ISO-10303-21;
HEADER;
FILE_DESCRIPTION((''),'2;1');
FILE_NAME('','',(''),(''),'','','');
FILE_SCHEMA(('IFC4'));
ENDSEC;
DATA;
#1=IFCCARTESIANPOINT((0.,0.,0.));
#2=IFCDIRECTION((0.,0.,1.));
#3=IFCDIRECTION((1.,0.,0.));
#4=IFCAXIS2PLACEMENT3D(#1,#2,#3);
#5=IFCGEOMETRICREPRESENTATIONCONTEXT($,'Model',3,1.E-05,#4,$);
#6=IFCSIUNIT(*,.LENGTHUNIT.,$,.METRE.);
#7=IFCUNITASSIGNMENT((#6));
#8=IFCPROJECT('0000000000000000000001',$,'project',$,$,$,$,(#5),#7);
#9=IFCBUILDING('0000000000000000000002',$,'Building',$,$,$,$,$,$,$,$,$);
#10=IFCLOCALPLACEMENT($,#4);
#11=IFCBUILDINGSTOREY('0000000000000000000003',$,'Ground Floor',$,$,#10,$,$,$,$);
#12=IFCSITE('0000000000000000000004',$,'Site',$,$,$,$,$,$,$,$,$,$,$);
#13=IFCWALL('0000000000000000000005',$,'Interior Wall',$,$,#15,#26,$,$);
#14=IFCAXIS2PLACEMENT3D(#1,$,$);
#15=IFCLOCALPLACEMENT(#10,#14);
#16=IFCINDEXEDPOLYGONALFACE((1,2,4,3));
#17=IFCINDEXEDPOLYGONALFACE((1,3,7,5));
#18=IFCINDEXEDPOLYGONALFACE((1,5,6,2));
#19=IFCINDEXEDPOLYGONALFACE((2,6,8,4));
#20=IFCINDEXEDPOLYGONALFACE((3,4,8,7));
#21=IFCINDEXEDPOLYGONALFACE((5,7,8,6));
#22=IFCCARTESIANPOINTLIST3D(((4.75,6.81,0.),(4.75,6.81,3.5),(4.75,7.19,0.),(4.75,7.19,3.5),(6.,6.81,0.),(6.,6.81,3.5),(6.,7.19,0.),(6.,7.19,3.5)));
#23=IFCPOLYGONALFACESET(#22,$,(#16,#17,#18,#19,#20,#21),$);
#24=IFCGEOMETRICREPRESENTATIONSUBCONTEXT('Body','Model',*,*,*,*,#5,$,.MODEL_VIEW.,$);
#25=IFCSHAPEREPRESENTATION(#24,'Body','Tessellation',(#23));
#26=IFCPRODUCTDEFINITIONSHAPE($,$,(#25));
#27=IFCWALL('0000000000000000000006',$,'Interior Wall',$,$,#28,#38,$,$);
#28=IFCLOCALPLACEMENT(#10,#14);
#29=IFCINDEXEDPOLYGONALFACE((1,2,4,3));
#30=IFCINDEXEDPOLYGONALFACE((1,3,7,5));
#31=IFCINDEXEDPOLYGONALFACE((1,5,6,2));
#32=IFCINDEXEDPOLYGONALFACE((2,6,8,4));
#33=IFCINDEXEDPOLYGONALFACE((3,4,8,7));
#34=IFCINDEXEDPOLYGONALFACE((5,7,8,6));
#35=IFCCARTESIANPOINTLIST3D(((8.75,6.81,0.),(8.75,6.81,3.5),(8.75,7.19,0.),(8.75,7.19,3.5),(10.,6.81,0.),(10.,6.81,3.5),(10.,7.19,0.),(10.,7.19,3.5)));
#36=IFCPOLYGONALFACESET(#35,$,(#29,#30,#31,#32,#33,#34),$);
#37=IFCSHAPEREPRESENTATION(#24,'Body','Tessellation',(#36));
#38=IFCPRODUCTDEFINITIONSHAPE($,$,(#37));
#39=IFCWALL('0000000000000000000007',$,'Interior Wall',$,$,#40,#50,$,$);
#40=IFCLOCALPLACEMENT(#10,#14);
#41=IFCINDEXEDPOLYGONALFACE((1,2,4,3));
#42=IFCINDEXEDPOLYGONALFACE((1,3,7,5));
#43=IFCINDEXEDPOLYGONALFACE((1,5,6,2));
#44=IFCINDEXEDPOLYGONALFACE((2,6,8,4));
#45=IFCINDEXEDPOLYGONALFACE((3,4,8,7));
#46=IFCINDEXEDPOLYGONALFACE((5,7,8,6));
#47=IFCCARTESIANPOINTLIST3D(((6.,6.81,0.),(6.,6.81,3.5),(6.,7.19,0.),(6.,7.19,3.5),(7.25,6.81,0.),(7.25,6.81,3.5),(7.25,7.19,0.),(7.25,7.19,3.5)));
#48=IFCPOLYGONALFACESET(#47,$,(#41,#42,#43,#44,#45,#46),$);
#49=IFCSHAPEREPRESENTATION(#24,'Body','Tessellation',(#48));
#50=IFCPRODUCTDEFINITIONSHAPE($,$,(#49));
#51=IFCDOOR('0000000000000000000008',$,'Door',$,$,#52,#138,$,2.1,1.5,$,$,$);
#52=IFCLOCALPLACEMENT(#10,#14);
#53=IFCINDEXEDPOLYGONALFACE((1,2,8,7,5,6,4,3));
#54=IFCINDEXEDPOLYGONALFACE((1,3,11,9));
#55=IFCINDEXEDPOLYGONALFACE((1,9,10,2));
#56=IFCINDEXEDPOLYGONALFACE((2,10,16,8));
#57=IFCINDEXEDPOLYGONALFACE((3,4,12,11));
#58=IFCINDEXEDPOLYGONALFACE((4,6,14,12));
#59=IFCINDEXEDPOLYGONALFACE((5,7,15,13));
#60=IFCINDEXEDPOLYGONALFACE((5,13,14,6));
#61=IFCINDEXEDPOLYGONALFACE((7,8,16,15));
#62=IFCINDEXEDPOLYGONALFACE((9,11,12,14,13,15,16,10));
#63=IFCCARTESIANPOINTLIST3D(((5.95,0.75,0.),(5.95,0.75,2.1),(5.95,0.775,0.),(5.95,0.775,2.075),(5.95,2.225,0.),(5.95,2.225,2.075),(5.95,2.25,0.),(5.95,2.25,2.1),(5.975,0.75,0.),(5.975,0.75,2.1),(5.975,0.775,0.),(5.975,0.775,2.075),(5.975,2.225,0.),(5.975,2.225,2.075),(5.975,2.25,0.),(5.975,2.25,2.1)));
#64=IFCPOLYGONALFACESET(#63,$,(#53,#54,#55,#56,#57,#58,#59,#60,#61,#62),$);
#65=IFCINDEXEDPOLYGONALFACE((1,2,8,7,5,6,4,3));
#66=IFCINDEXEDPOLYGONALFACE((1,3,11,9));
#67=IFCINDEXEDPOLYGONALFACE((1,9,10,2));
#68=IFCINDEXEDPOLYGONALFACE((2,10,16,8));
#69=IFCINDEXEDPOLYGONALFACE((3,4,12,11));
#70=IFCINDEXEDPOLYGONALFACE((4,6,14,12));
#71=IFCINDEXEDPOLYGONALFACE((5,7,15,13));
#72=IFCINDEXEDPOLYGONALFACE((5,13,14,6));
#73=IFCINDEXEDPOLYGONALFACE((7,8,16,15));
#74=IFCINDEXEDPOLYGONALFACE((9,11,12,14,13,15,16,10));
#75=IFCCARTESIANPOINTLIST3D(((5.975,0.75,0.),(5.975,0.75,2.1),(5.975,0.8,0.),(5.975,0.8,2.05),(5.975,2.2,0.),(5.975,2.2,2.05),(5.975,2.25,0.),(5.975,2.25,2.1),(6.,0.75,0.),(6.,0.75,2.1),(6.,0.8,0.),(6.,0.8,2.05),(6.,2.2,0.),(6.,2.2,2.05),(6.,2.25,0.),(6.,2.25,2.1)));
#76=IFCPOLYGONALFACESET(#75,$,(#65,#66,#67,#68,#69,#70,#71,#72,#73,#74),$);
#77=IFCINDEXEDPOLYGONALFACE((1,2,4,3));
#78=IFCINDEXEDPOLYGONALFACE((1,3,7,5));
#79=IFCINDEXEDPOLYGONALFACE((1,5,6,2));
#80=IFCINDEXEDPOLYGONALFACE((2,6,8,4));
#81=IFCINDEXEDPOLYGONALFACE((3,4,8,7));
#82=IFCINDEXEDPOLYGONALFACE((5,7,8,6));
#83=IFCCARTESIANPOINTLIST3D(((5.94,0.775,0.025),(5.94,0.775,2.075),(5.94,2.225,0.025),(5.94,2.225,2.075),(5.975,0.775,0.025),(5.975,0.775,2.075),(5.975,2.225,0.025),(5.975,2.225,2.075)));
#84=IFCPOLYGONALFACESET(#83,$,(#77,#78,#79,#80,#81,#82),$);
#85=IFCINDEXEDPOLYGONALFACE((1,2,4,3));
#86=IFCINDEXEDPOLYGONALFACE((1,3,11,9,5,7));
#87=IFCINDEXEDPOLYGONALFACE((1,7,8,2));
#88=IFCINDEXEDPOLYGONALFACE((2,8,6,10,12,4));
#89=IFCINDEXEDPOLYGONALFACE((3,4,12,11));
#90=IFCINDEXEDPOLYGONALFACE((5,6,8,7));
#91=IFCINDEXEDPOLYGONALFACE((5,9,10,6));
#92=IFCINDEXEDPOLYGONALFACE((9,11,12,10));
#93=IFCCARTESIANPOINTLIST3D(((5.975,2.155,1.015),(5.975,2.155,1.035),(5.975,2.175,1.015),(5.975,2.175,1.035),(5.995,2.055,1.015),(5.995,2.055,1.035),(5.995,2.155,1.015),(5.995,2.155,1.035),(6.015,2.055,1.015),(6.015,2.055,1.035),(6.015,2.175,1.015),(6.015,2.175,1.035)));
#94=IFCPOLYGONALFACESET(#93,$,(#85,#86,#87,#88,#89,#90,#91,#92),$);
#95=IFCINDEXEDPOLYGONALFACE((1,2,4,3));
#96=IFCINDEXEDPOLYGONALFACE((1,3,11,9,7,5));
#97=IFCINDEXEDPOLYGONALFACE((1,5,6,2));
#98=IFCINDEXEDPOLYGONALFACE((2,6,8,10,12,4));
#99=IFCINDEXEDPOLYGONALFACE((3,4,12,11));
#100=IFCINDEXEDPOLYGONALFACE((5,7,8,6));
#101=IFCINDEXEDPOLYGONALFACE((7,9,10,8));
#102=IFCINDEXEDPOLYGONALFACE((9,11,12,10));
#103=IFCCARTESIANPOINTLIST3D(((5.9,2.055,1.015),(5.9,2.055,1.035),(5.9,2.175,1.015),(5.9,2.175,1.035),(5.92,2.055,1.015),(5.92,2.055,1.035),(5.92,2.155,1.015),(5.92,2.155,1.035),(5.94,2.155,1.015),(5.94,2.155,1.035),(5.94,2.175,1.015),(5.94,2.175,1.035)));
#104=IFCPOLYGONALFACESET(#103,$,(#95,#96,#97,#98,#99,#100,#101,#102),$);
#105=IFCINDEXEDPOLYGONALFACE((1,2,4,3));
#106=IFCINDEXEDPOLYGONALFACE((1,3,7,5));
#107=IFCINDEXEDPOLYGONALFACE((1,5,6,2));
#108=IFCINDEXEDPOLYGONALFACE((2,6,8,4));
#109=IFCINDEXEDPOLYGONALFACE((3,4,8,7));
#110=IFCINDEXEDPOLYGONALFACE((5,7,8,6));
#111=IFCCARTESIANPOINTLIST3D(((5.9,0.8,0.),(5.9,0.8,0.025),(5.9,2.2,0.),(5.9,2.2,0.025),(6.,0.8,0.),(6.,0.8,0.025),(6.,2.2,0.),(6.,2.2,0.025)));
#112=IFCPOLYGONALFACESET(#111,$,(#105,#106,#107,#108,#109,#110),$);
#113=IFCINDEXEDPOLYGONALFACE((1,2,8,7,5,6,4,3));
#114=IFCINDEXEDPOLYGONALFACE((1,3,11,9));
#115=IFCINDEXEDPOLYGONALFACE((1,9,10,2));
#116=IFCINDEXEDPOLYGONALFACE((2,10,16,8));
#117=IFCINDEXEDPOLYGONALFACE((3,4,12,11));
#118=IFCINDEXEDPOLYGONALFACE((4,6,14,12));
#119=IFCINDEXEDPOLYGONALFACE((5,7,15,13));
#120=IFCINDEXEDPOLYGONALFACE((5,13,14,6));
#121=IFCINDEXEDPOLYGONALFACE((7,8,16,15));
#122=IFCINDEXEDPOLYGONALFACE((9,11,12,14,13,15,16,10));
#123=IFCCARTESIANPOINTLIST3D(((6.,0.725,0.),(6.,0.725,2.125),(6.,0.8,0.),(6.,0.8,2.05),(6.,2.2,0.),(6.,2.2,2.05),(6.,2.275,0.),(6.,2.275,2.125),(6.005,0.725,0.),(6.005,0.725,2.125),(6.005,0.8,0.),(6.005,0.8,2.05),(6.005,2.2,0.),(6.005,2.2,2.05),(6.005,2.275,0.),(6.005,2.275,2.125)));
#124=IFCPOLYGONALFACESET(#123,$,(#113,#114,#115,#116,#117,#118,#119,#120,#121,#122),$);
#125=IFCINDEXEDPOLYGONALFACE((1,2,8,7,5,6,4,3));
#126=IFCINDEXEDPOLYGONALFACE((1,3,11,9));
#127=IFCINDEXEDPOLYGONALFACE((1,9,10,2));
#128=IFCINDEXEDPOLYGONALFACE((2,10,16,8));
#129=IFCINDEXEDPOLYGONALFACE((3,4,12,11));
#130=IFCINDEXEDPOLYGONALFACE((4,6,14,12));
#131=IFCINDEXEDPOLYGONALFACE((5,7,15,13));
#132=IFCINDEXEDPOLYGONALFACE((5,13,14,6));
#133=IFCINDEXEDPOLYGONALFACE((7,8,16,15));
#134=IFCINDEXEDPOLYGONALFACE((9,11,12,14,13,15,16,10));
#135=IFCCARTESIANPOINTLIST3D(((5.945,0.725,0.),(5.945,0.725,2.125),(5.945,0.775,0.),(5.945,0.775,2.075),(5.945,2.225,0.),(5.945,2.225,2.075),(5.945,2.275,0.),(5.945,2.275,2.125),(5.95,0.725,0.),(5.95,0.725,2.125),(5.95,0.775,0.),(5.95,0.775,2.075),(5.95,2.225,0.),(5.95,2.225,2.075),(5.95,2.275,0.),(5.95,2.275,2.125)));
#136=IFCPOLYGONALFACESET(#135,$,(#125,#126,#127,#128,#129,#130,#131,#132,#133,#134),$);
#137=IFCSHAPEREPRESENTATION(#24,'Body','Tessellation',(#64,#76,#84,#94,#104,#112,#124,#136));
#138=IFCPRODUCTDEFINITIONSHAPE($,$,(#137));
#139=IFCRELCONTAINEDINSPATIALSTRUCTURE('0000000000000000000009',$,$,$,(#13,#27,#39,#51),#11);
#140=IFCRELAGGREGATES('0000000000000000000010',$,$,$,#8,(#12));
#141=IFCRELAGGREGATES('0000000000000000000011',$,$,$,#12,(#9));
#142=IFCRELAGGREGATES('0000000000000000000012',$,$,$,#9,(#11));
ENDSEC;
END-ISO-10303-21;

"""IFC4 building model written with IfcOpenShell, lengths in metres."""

from ifc_helpers import new_model, si_unit, frame, origin_with_axes, place, context, subcontext, project, spatial, line, indexed_curve, outline, extrude, element, save


model = new_model("IFC4")

# Units and contexts
model_context = context("Model", 3, precision=1e-05, world=origin_with_axes())
body_context = subcontext(model_context, "Body", "Model", "MODEL_VIEW")
ifc_project = project(units=[si_unit("LENGTHUNIT", "METRE")], contexts=[model_context])

# Site, building, storey
site = spatial("IfcSite", under=ifc_project, Name="Site")
building = spatial("IfcBuilding", under=site, Name="Building")
storey_placement = place(None, origin_with_axes())
storey = spatial("IfcBuildingStorey", under=building, at=storey_placement, Name="Ground Floor")

# Walls
for number, where, z_axis, x_axis, name in (
    (1, (6.0, 7.0, 0.0), (0.0, 0.0, 1.0), (-1.0, 0.0, 0.0), "Interior Wall"),
    (2, (10.0, 7.0, 0.0), (0.0, 0.0, 1.0), (-1.0, 0.0, 0.0), "Interior Wall"),
    (3, (7.25, 7.0, 0.0), (0.0, 0.0, 1.0), (-1.0, 0.0, 0.0), "Interior Wall"),
):
    element("IfcWall", number, at=place(storey_placement, frame(where, z_axis=z_axis, x_axis=x_axis)), inside=storey, Name=name, context=body_context, shape_type="SweptSolid", body=[
        extrude(outline(indexed_curve([(0.0, 0.0), (0.0, 0.38), (1.25, 0.38), (1.25, 0.0), (0.0, 0.0)], self_intersect=False)), frame((0.0, -0.19, 0.0), z_axis=(0.0, 0.0, 1.0), x_axis=(1.0, 0.0, 0.0)), (0.0, 0.0, 1.0), 3.5),
    ])

# Door
door_1_placement = place(storey_placement, frame((6.0, 0.75, 0.0), z_axis=(0.0, 0.0, 1.0), x_axis=(0.0, 1.0, 0.0)))
element("IfcDoor", 4, at=door_1_placement, inside=storey, Name="Door", OverallHeight=2.1, OverallWidth=1.5, context=body_context, shape_type="SweptSolid", body=[
    extrude(outline(indexed_curve([(0.0, 0.0), (0.0, 2.1), (1.5, 2.1), (1.5, 0.0), (1.475, 0.0), (1.475, 2.075), (0.025, 2.075), (0.025, 0.0)], segments=[line(1, 2, 3, 4, 5, 6, 7, 8, 1)])), frame((0.0, 0.025, 0.0), z_axis=(0.0, -1.0, 0.0), x_axis=(1.0, 0.0, 0.0)), (0.0, 0.0, -1.0), 0.025),
    extrude(outline(indexed_curve([(0.0, 0.0), (0.0, 2.1), (1.5, 2.1), (1.5, 0.0), (1.45, 0.0), (1.45, 2.05), (0.05, 2.05), (0.05, 0.0)], segments=[line(1, 2, 3, 4, 5, 6, 7, 8, 1)])), frame((0.0, 0.0, 0.0), z_axis=(0.0, -1.0, 0.0), x_axis=(1.0, 0.0, 0.0)), (0.0, 0.0, -1.0), 0.025),
    extrude(outline(indexed_curve([(0.0, 0.0), (1.45, 0.0), (1.45, 0.035), (0.0, 0.035)], segments=[line(1, 2, 3, 4, 1)])), frame((0.025, 0.025, 0.025), z_axis=(0.0, 0.0, 1.0), x_axis=(1.0, 0.0, 0.0)), (0.0, 0.0, 1.0), 2.05),
    extrude(outline(indexed_curve([(0.0, 0.0), (0.0, -0.04), (-0.12, -0.04), (-0.12, -0.02), (-0.02, -0.02), (-0.02, 0.0)], segments=[line(1, 2, 3, 4, 5, 6, 1)])), frame((1.425, 0.025, 1.015), z_axis=(0.0, 0.0, 1.0), x_axis=(1.0, 0.0, 0.0)), (0.0, 0.0, 1.0), 0.02),
    extrude(outline(indexed_curve([(0.0, 0.0), (0.0, 0.04), (-0.12, 0.04), (-0.12, 0.02), (-0.02, 0.02), (-0.02, 0.0)], segments=[line(1, 2, 3, 4, 5, 6, 1)])), frame((1.425, 0.06, 1.015), z_axis=(0.0, 0.0, 1.0), x_axis=(1.0, 0.0, 0.0)), (0.0, 0.0, 1.0), 0.02),
    extrude(outline(indexed_curve([(0.0, 0.0), (1.4, 0.0), (1.4, 0.1), (0.0, 0.1)], segments=[line(1, 2, 3, 4, 1)])), frame((0.05, 0.0, 0.0), z_axis=(0.0, 0.0, 1.0), x_axis=(1.0, 0.0, 0.0)), (0.0, 0.0, 1.0), 0.025),
    extrude(outline(indexed_curve([(0.0, 0.0), (0.0, 2.125), (1.55, 2.125), (1.55, 0.0), (1.475, 0.0), (1.475, 2.05), (0.075, 2.05), (0.075, 0.0)], segments=[line(1, 2, 3, 4, 5, 6, 7, 8, 1)])), frame((-0.025, -0.005, 0.0), z_axis=(0.0, -1.0, 0.0), x_axis=(1.0, 0.0, 0.0)), (0.0, 0.0, -1.0), 0.005),
    extrude(outline(indexed_curve([(0.0, 0.0), (0.0, 2.125), (1.55, 2.125), (1.55, 0.0), (1.5, 0.0), (1.5, 2.075), (0.05, 2.075), (0.05, 0.0)], segments=[line(1, 2, 3, 4, 5, 6, 7, 8, 1)])), frame((-0.025, 0.05, 0.0), z_axis=(0.0, -1.0, 0.0), x_axis=(1.0, 0.0, 0.0)), (0.0, 0.0, -1.0), 0.005),
])

save(model, "model.ifc")
